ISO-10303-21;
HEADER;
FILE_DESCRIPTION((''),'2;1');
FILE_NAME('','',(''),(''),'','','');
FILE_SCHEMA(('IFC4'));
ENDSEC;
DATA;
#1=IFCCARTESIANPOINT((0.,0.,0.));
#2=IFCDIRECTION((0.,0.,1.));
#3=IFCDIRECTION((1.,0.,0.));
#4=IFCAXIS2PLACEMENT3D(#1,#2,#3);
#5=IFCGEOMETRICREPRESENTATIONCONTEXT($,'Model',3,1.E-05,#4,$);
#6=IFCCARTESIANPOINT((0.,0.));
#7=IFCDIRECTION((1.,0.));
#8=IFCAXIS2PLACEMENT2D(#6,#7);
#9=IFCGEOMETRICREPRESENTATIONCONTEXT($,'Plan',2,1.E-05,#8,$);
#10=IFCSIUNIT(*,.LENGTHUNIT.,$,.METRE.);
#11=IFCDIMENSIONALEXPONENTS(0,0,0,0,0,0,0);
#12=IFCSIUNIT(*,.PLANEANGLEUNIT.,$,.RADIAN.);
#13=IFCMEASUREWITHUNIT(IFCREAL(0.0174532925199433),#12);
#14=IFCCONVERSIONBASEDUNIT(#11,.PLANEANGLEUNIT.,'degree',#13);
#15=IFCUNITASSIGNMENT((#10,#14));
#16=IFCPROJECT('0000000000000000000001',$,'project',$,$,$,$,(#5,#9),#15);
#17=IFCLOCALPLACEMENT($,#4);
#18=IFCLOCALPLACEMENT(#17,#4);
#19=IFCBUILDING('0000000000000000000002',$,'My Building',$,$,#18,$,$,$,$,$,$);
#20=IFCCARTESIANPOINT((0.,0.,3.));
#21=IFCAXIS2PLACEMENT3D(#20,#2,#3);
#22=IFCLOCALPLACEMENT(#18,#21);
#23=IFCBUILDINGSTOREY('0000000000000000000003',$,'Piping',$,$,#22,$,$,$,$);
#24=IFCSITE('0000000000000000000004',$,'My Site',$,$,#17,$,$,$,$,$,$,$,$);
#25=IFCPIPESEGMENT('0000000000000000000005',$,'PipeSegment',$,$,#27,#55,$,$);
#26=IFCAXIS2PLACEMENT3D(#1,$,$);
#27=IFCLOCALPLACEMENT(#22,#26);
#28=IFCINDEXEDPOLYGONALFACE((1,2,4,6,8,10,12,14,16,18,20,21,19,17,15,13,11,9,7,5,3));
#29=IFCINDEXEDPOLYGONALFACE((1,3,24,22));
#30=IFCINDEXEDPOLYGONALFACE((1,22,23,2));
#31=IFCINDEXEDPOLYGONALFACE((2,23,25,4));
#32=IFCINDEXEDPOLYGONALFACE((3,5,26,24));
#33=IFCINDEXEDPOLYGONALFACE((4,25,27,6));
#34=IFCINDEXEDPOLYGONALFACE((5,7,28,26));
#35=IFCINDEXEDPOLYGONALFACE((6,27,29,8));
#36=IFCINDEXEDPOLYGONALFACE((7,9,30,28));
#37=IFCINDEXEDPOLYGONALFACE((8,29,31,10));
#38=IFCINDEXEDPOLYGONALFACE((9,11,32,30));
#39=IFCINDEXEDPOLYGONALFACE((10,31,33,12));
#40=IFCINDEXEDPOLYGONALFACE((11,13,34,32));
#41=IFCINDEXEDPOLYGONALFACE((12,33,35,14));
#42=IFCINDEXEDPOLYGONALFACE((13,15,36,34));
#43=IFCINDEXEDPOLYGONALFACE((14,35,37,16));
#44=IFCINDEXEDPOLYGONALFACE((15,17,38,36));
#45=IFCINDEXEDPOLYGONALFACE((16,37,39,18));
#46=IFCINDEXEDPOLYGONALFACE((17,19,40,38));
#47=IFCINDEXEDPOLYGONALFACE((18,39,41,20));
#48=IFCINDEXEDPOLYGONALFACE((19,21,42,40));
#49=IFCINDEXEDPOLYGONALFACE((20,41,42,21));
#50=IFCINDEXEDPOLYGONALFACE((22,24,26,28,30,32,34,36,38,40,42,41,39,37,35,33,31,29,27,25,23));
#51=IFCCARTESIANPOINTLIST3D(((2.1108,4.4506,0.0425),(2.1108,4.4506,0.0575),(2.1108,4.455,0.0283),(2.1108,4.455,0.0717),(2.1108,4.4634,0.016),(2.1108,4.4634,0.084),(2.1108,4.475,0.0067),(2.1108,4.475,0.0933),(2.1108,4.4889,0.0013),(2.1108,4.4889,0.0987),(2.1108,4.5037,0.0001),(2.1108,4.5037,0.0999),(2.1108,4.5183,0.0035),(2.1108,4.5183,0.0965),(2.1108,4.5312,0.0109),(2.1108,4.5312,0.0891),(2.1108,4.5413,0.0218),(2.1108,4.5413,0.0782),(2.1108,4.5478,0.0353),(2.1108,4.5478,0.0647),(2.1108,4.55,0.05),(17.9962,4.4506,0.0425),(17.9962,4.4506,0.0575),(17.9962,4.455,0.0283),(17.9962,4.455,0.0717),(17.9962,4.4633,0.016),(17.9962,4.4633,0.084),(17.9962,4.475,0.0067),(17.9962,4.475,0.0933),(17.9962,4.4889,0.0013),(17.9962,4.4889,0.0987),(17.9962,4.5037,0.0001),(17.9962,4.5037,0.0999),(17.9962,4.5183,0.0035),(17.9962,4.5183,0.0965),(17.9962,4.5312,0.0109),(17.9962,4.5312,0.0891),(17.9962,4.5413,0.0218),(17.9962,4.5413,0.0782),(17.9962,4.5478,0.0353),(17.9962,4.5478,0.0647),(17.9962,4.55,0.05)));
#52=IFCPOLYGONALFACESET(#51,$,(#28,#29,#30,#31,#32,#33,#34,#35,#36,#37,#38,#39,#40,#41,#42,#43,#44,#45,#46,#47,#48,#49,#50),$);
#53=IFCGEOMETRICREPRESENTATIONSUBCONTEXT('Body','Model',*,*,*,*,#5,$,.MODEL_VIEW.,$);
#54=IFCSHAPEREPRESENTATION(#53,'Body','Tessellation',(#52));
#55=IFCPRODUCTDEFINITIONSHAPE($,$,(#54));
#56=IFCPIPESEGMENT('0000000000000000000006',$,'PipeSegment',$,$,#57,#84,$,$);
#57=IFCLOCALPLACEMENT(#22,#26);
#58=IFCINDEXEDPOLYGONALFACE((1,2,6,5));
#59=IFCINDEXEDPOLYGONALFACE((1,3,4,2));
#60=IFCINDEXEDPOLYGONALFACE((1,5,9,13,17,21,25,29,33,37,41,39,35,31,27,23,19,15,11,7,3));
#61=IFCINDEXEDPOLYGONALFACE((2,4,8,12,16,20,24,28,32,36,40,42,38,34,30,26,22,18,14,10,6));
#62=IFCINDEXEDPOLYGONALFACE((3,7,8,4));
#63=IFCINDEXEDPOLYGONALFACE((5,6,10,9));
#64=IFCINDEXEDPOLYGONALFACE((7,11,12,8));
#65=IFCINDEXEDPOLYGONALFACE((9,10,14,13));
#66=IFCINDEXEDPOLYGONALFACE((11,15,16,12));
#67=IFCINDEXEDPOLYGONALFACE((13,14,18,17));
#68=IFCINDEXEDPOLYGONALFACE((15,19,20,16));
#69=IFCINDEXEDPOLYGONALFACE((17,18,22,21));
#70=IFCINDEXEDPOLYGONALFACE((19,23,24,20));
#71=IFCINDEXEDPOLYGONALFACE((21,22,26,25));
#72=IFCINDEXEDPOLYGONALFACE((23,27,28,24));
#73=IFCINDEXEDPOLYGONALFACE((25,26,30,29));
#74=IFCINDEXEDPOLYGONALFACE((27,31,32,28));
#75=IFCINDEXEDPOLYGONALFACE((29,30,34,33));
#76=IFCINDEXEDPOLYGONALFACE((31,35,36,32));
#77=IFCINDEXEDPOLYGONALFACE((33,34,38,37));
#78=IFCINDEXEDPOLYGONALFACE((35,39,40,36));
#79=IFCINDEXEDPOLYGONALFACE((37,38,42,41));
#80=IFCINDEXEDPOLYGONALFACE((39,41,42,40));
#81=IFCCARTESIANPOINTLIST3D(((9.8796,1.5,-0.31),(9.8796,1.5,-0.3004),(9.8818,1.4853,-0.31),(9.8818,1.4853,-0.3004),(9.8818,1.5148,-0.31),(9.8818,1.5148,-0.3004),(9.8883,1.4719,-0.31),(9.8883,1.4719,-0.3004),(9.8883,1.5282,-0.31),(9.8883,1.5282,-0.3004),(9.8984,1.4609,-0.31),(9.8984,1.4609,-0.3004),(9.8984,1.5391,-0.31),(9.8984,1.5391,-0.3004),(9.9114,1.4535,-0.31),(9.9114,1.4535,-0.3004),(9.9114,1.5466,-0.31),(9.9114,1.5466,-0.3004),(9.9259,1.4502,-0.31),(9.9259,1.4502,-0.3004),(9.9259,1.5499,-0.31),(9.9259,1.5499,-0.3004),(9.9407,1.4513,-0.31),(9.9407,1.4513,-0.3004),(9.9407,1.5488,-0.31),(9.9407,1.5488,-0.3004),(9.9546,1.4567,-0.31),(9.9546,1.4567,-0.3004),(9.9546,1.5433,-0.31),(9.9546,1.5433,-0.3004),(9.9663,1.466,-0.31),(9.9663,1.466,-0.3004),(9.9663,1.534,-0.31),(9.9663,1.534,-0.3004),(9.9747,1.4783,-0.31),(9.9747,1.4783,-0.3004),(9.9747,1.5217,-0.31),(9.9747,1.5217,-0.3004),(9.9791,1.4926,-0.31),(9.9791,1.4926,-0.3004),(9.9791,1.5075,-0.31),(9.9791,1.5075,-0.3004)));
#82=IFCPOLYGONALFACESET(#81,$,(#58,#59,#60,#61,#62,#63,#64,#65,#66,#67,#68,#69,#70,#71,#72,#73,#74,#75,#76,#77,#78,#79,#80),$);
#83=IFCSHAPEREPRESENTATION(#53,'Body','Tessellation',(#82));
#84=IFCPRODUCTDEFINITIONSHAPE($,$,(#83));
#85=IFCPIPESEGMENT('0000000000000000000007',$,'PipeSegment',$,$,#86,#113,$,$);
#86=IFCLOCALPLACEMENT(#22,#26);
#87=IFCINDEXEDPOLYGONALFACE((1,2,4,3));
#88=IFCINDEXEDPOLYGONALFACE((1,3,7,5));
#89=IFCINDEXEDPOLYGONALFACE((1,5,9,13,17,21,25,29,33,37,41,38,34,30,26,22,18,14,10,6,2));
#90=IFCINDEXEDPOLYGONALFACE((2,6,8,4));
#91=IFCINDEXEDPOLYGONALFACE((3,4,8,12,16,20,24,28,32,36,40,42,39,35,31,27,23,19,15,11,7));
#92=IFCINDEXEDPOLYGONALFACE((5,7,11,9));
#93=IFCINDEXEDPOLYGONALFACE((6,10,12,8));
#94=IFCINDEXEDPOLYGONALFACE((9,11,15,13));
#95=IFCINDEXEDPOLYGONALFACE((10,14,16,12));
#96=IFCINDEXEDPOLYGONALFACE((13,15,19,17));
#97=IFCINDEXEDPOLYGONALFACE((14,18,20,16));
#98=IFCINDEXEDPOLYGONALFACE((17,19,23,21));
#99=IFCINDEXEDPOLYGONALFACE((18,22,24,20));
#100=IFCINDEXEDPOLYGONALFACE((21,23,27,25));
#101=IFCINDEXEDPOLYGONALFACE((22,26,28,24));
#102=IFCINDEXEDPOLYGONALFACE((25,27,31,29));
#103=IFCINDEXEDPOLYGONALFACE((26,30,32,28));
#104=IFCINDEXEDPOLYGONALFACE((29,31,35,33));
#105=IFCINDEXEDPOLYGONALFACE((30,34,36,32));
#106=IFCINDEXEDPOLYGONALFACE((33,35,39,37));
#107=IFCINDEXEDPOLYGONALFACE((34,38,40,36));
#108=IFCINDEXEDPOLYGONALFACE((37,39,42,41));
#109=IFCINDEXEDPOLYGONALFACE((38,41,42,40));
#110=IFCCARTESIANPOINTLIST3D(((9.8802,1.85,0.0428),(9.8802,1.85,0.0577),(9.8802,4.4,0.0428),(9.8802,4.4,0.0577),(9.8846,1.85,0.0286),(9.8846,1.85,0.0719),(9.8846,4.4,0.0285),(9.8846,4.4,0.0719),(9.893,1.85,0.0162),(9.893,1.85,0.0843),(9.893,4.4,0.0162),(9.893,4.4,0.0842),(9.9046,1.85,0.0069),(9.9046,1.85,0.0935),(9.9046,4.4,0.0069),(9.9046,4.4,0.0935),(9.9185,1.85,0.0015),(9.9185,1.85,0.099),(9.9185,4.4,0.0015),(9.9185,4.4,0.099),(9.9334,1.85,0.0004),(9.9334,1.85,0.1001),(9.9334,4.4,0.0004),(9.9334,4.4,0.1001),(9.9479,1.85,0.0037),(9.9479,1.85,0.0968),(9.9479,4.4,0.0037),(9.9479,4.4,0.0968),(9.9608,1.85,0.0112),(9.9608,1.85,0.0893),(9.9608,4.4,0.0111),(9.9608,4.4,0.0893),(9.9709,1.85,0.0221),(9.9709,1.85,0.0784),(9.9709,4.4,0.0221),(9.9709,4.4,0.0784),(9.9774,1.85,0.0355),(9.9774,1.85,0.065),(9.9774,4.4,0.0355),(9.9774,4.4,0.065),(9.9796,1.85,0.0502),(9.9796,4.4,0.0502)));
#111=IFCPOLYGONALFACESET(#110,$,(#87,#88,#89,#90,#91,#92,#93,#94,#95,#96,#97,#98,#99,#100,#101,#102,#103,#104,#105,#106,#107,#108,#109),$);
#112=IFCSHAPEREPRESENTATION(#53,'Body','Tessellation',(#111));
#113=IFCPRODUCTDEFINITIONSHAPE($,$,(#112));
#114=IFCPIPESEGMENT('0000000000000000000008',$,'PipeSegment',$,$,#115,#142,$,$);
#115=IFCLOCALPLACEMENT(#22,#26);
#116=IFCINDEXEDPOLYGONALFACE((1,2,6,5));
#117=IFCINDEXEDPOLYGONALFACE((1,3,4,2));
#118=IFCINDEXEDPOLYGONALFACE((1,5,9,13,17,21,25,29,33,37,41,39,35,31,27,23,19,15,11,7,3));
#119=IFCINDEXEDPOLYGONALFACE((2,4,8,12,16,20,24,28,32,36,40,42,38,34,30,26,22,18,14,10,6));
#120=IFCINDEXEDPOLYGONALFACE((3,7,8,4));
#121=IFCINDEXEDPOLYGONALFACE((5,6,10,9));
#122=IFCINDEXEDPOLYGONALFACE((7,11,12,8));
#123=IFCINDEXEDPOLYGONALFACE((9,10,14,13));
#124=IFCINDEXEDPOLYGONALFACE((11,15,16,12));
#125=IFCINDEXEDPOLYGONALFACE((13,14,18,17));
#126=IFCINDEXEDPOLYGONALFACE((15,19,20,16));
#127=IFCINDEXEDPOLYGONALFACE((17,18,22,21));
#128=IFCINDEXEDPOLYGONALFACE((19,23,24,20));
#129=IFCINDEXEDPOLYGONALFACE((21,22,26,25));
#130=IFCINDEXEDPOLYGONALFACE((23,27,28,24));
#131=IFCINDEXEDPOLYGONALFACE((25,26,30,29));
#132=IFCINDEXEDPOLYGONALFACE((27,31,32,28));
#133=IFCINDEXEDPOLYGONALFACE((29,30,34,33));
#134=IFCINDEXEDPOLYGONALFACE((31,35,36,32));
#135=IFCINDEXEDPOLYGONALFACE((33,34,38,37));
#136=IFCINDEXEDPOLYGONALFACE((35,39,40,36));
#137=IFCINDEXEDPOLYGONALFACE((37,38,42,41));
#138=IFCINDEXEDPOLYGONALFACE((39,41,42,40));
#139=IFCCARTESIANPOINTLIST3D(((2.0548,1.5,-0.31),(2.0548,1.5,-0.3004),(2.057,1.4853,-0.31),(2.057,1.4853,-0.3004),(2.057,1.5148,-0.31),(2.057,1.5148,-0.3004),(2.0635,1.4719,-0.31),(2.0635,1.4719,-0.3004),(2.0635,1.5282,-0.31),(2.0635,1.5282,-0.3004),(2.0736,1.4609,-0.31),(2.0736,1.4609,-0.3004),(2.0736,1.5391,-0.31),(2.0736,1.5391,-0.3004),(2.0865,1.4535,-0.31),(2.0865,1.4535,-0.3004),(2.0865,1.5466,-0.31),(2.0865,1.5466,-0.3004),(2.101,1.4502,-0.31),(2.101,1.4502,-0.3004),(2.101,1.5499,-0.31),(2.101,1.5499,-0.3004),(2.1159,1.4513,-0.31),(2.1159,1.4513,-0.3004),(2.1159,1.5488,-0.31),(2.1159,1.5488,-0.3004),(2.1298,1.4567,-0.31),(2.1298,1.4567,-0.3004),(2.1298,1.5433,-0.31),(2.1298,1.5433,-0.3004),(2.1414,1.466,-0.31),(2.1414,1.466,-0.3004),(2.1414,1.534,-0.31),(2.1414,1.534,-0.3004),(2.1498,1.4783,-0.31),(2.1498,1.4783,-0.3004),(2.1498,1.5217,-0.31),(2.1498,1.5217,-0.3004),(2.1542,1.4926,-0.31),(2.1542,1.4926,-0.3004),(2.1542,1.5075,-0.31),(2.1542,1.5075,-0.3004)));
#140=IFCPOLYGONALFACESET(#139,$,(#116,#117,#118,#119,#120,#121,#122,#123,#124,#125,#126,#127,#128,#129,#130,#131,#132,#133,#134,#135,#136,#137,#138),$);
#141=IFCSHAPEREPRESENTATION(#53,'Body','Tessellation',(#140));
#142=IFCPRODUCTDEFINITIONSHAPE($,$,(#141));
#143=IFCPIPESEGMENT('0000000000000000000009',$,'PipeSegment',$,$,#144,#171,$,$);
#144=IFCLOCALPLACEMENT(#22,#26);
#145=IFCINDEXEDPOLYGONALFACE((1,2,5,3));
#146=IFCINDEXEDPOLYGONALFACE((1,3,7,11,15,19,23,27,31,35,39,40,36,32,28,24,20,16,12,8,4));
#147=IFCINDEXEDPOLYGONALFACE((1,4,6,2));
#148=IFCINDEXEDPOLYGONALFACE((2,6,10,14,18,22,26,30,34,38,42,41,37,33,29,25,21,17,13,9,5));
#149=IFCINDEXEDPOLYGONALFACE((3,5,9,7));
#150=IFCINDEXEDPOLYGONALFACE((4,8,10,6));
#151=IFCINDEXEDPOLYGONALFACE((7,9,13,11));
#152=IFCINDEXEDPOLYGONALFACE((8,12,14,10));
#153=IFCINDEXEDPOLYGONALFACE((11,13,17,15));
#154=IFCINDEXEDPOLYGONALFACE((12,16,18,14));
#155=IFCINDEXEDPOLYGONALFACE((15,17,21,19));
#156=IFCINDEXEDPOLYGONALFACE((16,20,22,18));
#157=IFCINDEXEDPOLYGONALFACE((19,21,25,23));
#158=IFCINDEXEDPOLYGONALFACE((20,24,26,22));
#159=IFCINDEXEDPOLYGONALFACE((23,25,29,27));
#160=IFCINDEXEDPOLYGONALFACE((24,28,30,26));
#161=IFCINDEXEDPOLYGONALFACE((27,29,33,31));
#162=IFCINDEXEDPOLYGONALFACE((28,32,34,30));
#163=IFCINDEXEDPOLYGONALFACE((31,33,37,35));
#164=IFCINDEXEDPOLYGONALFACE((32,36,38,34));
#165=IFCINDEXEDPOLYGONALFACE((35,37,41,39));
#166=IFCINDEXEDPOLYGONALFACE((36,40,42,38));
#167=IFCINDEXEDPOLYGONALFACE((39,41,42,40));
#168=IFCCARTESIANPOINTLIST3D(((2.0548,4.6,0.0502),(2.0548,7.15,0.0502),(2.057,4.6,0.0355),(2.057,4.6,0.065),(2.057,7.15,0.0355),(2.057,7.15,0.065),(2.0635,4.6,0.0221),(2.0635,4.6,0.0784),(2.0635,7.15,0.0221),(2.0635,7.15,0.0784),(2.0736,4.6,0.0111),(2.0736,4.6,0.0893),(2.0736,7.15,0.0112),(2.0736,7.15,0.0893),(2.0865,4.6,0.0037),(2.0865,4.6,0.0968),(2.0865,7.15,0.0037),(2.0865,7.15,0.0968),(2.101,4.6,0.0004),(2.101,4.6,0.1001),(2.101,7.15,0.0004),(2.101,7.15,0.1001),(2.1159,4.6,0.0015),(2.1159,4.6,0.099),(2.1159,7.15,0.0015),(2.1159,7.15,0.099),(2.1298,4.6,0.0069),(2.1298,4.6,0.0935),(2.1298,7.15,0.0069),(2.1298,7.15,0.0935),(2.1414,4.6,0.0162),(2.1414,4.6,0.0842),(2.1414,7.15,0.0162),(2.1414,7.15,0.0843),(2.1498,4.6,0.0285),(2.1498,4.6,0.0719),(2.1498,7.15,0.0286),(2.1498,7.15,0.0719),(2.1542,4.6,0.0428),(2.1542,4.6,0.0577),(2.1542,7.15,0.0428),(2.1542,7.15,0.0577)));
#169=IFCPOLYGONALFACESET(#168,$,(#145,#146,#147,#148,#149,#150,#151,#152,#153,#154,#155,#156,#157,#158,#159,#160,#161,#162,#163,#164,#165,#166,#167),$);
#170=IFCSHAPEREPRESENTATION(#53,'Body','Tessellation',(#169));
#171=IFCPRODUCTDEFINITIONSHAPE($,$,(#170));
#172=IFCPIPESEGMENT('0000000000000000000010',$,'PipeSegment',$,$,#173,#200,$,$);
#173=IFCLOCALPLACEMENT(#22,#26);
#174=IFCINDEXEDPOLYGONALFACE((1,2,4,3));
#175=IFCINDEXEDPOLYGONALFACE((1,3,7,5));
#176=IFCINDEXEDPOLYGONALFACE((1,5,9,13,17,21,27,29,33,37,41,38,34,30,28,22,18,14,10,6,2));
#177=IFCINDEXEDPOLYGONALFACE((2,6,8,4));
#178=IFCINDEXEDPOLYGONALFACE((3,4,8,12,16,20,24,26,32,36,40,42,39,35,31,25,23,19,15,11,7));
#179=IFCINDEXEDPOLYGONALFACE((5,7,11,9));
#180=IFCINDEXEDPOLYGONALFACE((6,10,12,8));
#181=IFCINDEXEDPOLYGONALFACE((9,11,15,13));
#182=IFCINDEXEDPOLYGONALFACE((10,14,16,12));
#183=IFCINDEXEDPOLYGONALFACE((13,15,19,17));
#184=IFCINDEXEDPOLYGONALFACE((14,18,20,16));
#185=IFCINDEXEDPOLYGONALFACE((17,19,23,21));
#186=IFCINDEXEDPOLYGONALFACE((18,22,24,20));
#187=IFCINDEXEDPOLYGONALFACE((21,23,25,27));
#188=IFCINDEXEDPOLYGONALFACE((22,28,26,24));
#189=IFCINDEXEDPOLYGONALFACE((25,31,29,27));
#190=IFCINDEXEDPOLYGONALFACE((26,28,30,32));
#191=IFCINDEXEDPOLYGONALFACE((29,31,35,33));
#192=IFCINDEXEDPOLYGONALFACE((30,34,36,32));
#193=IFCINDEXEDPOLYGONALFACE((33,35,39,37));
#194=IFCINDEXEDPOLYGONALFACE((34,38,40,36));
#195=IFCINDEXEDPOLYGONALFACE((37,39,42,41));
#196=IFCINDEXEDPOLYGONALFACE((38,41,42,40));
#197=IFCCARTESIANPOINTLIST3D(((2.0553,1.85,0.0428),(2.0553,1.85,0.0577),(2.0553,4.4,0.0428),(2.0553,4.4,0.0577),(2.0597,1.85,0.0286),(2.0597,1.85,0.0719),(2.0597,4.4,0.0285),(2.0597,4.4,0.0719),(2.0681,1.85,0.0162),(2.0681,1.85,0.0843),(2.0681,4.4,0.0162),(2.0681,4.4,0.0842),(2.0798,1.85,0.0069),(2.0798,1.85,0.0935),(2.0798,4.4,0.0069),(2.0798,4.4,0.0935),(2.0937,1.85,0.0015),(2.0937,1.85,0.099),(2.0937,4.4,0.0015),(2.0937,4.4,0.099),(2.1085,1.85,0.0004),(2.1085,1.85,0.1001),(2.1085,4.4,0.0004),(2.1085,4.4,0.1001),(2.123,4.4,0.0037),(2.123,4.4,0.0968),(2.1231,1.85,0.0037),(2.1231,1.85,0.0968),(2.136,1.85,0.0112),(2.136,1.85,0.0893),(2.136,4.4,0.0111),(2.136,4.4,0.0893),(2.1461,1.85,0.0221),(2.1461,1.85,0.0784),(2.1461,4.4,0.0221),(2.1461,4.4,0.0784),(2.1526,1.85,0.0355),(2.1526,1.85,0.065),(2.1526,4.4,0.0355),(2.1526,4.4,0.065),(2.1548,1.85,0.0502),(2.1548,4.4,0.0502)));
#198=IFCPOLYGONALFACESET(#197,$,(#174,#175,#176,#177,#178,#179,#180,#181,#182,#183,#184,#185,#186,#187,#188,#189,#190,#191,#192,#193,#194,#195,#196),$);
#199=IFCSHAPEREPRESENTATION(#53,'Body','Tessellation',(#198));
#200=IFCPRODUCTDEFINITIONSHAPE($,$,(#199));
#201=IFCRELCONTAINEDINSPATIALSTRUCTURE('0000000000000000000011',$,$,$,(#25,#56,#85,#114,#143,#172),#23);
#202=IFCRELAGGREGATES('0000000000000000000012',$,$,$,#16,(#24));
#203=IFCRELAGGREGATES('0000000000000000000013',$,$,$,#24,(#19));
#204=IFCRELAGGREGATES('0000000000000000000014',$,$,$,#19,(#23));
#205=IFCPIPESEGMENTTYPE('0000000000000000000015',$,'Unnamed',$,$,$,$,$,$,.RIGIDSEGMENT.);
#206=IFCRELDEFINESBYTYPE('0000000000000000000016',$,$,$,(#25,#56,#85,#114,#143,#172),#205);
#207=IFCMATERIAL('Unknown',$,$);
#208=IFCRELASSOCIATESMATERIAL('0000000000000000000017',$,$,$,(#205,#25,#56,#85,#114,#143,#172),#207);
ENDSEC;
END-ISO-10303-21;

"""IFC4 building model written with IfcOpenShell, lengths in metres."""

from ifc_helpers import new_model, entity, si_unit, converted_unit, frame, origin_with_axes, origin_2d_with_axis, place, context, subcontext, project, spatial, circle, extrude, material, material_profile, profile_set, profile_usage, type_object, element, save


model = new_model("IFC4")

# Units and contexts
model_context = context("Model", 3, precision=1e-05, world=origin_with_axes())
plan_context = context("Plan", 2, precision=1e-05, world=origin_2d_with_axis())
body_context = subcontext(model_context, "Body", "Model", "MODEL_VIEW")
ifc_project = project(units=[si_unit("LENGTHUNIT", "METRE"), converted_unit("PLANEANGLEUNIT", "degree", entity("IfcReal", 0.0174532925199433), si_unit("PLANEANGLEUNIT", "RADIAN"), dimensions=[0, 0, 0, 0, 0, 0, 0])], contexts=[model_context, plan_context])

# Site, building, storey
site_placement = place(None, origin_with_axes())
site = spatial("IfcSite", under=ifc_project, at=site_placement, Name="My Site")
building_placement = place(site_placement, origin_with_axes())
building = spatial("IfcBuilding", under=site, at=building_placement, Name="My Building")
storey_placement = place(building_placement, frame((0.0, 0.0, 3.0), z_axis=(0.0, 0.0, 1.0), x_axis=(1.0, 0.0, 0.0)))
storey = spatial("IfcBuildingStorey", under=building, at=storey_placement, Name="Piping")

# Pipe segments
ifc_material = material(Name="Unknown")
ifc_material_profile_1 = material_profile(ifc_material, circle(Radius=0.05))
ifc_profile_set_1 = profile_set([ifc_material_profile_1])
ifc_profile_usage_1 = profile_usage(ifc_profile_set_1, cardinal=2)
pipe_segment_type = type_object("IfcPipeSegmentType", Name="Unnamed", PredefinedType="RIGIDSEGMENT", material=ifc_profile_set_1)
pipe_segment_1_placement = place(storey_placement, frame((2.1108, 4.5, 0.0), z_axis=(1.0, 0.0, 0.0), x_axis=(0.0, 1.0, 0.0)))
element("IfcPipeSegment", 1, at=pipe_segment_1_placement, inside=storey, type_object=pipe_segment_type, material=ifc_profile_usage_1, Name="PipeSegment", context=body_context, shape_type="SweptSolid", body=[
    extrude(circle(Radius=0.05), frame((0.0, 0.05, 0.0), z_axis=(0.0, 0.0, 1.0), x_axis=(1.0, 0.0, 0.0)), (0.0, 0.0, 1.0), 15.8854),
])
ifc_profile_usage_2 = profile_usage(ifc_profile_set_1, cardinal=16)
pipe_segment_2_placement = place(storey_placement, frame((9.9296, 1.5, -0.3004), z_axis=(0.0, 0.0, -1.0), x_axis=(-1.0, 0.0, 0.0)))
element("IfcPipeSegment", 2, at=pipe_segment_2_placement, inside=storey, type_object=pipe_segment_type, material=ifc_profile_usage_2, Name="PipeSegment", context=body_context, shape_type="SweptSolid", body=[
    extrude(circle(Radius=0.05), origin_with_axes(), (0.0, 0.0, 1.0), 0.0096),
])
ifc_profile_usage_3 = profile_usage(ifc_profile_set_1, cardinal=2)
pipe_segment_3_placement = place(storey_placement, frame((9.9296, 4.4, 0.0002), z_axis=(0.0, -1.0, 0.000006), x_axis=(1.0, 0.0, 0.0)))
element("IfcPipeSegment", 3, at=pipe_segment_3_placement, inside=storey, type_object=pipe_segment_type, material=ifc_profile_usage_3, Name="PipeSegment", context=body_context, shape_type="SweptSolid", body=[
    extrude(circle(Radius=0.05), frame((0.0, 0.05, 0.0), z_axis=(0.0, 0.0, 1.0), x_axis=(1.0, 0.0, 0.0)), (0.0, 0.0, 1.0), 2.55),
])
ifc_profile_usage_4 = profile_usage(ifc_profile_set_1, cardinal=16)
pipe_segment_4_placement = place(storey_placement, frame((2.1048, 1.5, -0.3004), z_axis=(0.0, 0.0, -1.0), x_axis=(-1.0, 0.0, 0.0)))
element("IfcPipeSegment", 4, at=pipe_segment_4_placement, inside=storey, type_object=pipe_segment_type, material=ifc_profile_usage_4, Name="PipeSegment", context=body_context, shape_type="SweptSolid", body=[
    extrude(circle(Radius=0.05), origin_with_axes(), (0.0, 0.0, 1.0), 0.0096),
])
ifc_profile_usage_5 = profile_usage(ifc_profile_set_1, cardinal=2)
pipe_segment_5_placement = place(storey_placement, frame((2.1048, 4.6, 0.0002), z_axis=(0.0, 1.0, 0.000006), x_axis=(-1.0, 0.0, 0.0)))
element("IfcPipeSegment", 5, at=pipe_segment_5_placement, inside=storey, type_object=pipe_segment_type, material=ifc_profile_usage_5, Name="PipeSegment", context=body_context, shape_type="SweptSolid", body=[
    extrude(circle(Radius=0.05), frame((0.0, 0.05, 0.0), z_axis=(0.0, 0.0, 1.0), x_axis=(1.0, 0.0, 0.0)), (0.0, 0.0, 1.0), 2.55),
])
ifc_profile_usage_6 = profile_usage(ifc_profile_set_1, cardinal=2)
pipe_segment_6_placement = place(storey_placement, frame((2.1048, 4.4, 0.0002), z_axis=(0.0, -1.0, 0.000006), x_axis=(1.0, 0.0, 0.0)))
element("IfcPipeSegment", 6, at=pipe_segment_6_placement, inside=storey, type_object=pipe_segment_type, material=ifc_profile_usage_6, Name="PipeSegment", context=body_context, shape_type="SweptSolid", body=[
    extrude(circle(Radius=0.05), frame((0.0, 0.05, 0.0), z_axis=(0.0, 0.0, 1.0), x_axis=(1.0, 0.0, 0.0)), (0.0, 0.0, 1.0), 2.55),
])

save(model, "model.ifc")
